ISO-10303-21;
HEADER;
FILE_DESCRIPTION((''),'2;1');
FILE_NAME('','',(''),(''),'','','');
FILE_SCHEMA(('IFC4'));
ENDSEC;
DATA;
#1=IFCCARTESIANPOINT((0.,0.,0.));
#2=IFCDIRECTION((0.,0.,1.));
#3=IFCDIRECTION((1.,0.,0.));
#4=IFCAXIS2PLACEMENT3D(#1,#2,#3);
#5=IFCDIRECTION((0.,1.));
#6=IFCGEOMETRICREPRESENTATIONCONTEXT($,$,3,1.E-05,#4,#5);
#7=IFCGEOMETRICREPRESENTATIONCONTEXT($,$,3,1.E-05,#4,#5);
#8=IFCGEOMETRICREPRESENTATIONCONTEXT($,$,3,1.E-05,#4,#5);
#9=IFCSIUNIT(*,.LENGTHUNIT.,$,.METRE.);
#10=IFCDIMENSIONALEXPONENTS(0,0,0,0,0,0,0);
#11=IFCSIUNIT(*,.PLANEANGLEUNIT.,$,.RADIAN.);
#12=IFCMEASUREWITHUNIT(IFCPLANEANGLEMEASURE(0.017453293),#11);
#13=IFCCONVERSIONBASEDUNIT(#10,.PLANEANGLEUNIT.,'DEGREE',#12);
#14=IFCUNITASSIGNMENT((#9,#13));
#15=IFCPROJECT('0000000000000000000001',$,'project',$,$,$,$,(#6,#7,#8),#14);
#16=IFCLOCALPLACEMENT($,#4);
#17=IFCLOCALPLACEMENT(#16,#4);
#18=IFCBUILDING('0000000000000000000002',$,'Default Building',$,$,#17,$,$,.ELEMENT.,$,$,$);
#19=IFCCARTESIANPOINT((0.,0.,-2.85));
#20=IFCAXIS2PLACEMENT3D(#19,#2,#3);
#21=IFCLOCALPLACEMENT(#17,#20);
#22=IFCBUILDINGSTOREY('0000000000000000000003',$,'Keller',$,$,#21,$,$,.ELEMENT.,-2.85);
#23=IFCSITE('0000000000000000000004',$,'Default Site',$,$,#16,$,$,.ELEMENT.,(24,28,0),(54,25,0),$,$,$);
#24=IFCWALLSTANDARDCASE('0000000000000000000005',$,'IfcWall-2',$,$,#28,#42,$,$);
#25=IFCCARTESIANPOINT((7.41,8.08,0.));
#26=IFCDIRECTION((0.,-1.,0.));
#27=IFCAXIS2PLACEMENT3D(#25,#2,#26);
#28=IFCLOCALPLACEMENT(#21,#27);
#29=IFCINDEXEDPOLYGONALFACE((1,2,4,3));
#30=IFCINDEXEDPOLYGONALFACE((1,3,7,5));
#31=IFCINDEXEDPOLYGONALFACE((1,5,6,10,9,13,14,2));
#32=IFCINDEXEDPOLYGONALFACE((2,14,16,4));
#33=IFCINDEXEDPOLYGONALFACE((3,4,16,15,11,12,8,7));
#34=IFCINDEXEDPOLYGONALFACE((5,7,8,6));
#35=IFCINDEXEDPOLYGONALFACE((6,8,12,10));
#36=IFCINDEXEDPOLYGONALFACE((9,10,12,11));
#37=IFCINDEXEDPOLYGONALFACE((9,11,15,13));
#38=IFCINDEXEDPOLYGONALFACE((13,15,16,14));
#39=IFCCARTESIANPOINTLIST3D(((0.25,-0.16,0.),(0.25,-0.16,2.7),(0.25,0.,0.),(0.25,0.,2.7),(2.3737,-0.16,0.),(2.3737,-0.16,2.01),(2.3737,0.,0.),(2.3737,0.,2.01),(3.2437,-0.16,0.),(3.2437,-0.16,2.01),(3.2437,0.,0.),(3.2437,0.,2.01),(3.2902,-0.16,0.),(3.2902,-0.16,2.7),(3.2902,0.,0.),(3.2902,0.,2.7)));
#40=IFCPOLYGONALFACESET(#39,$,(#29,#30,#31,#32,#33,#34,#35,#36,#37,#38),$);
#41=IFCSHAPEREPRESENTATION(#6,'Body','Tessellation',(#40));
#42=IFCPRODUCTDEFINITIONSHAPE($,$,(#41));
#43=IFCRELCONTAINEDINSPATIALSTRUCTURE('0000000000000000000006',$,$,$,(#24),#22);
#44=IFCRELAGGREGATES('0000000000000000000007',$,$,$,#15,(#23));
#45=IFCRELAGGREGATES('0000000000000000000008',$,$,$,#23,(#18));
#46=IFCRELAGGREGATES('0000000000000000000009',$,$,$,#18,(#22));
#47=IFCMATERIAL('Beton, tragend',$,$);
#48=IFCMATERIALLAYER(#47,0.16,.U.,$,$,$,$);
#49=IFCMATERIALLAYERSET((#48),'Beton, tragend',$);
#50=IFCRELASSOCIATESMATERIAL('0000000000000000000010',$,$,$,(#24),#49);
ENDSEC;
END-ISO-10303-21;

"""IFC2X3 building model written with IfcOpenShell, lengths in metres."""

from ifc_helpers import new_model, entity, si_unit, converted_unit, direction, frame, frame_2d, origin_with_axes, place, context, project, spatial, polyline, rectangle, outline, extrude, material, layer, layer_set, layer_usage, element, save


model = new_model("IFC2X3")

# Units and contexts
context_of_model_1 = context(None, 3, precision=1e-05, world=origin_with_axes(), true_north=direction((0.0, 1.0)))
context_of_model_2 = context(None, 3, precision=1e-05, world=origin_with_axes(), true_north=direction((0.0, 1.0)))
context_of_model_3 = context(None, 3, precision=1e-05, world=origin_with_axes(), true_north=direction((0.0, 1.0)))
ifc_project = project(units=[si_unit("LENGTHUNIT", "METRE"), converted_unit("PLANEANGLEUNIT", "DEGREE", entity("IfcPlaneAngleMeasure", 0.017453293), si_unit("PLANEANGLEUNIT", "RADIAN"), dimensions=[0, 0, 0, 0, 0, 0, 0])], contexts=[context_of_model_1, context_of_model_2, context_of_model_3])

# Site, building, storey
site_placement = place(None, origin_with_axes())
site = spatial("IfcSite", under=ifc_project, at=site_placement, Name="Default Site", CompositionType="ELEMENT", RefLatitude=(24, 28, 0), RefLongitude=(54, 25, 0))
building_placement = place(site_placement, origin_with_axes())
building = spatial("IfcBuilding", under=site, at=building_placement, Name="Default Building", CompositionType="ELEMENT")
storey_placement = place(building_placement, frame((0.0, 0.0, -2.85), z_axis=(0.0, 0.0, 1.0), x_axis=(1.0, 0.0, 0.0)))
storey = spatial("IfcBuildingStorey", under=building, at=storey_placement, Name="Keller", CompositionType="ELEMENT", Elevation=-2.85)

# Shared definitions
ifc_material_1 = material(Name="Beton, tragend")

# Wall, opening
ifc_layer_1 = layer(ifc_material_1, 0.16, ventilated="UNKNOWN")
ifc_layer_set_1 = layer_set([ifc_layer_1], Name="Beton, tragend")
ifc_layer_usage_1 = layer_usage(ifc_layer_set_1, "AXIS2", "NEGATIVE", 0.0)
wall_1_placement = place(storey_placement, frame((7.41, 8.08, 0.0), z_axis=(0.0, 0.0, 1.0), x_axis=(0.0, -1.0, 0.0)))
wall_1 = element("IfcWallStandardCase", 1, at=wall_1_placement, inside=storey, material=ifc_layer_usage_1, Name="IfcWall-2", context=context_of_model_1, shape_type="SweptSolid", body=[
    extrude(outline(polyline([(0.25, -0.16), (3.2902, -0.16), (3.2902, 0.0), (0.25, 0.0), (0.25, -0.16)])), origin_with_axes(), (0.0, 0.0, 1.0), 2.7),
])
opening_1_placement = place(wall_1_placement, frame((2.8087, -0.16, 0.0), z_axis=(0.0, 0.0, 1.0), x_axis=(1.0, 0.0, 0.0)))
element("IfcOpeningElement", 2, at=opening_1_placement, cuts=wall_1, context=context_of_model_1, shape_type="SweptSolid", body=[
    extrude(rectangle(XDim=2.01, YDim=0.87, at=frame_2d((0.0, 1.005), x_axis=(0.0, -1.0))), frame((0.0, 0.0, 0.0), z_axis=(0.0, 1.0, 0.0), x_axis=(-1.0, 0.0, 0.0)), (0.0, 0.0, 1.0), 0.16),
])

save(model, "model.ifc")
